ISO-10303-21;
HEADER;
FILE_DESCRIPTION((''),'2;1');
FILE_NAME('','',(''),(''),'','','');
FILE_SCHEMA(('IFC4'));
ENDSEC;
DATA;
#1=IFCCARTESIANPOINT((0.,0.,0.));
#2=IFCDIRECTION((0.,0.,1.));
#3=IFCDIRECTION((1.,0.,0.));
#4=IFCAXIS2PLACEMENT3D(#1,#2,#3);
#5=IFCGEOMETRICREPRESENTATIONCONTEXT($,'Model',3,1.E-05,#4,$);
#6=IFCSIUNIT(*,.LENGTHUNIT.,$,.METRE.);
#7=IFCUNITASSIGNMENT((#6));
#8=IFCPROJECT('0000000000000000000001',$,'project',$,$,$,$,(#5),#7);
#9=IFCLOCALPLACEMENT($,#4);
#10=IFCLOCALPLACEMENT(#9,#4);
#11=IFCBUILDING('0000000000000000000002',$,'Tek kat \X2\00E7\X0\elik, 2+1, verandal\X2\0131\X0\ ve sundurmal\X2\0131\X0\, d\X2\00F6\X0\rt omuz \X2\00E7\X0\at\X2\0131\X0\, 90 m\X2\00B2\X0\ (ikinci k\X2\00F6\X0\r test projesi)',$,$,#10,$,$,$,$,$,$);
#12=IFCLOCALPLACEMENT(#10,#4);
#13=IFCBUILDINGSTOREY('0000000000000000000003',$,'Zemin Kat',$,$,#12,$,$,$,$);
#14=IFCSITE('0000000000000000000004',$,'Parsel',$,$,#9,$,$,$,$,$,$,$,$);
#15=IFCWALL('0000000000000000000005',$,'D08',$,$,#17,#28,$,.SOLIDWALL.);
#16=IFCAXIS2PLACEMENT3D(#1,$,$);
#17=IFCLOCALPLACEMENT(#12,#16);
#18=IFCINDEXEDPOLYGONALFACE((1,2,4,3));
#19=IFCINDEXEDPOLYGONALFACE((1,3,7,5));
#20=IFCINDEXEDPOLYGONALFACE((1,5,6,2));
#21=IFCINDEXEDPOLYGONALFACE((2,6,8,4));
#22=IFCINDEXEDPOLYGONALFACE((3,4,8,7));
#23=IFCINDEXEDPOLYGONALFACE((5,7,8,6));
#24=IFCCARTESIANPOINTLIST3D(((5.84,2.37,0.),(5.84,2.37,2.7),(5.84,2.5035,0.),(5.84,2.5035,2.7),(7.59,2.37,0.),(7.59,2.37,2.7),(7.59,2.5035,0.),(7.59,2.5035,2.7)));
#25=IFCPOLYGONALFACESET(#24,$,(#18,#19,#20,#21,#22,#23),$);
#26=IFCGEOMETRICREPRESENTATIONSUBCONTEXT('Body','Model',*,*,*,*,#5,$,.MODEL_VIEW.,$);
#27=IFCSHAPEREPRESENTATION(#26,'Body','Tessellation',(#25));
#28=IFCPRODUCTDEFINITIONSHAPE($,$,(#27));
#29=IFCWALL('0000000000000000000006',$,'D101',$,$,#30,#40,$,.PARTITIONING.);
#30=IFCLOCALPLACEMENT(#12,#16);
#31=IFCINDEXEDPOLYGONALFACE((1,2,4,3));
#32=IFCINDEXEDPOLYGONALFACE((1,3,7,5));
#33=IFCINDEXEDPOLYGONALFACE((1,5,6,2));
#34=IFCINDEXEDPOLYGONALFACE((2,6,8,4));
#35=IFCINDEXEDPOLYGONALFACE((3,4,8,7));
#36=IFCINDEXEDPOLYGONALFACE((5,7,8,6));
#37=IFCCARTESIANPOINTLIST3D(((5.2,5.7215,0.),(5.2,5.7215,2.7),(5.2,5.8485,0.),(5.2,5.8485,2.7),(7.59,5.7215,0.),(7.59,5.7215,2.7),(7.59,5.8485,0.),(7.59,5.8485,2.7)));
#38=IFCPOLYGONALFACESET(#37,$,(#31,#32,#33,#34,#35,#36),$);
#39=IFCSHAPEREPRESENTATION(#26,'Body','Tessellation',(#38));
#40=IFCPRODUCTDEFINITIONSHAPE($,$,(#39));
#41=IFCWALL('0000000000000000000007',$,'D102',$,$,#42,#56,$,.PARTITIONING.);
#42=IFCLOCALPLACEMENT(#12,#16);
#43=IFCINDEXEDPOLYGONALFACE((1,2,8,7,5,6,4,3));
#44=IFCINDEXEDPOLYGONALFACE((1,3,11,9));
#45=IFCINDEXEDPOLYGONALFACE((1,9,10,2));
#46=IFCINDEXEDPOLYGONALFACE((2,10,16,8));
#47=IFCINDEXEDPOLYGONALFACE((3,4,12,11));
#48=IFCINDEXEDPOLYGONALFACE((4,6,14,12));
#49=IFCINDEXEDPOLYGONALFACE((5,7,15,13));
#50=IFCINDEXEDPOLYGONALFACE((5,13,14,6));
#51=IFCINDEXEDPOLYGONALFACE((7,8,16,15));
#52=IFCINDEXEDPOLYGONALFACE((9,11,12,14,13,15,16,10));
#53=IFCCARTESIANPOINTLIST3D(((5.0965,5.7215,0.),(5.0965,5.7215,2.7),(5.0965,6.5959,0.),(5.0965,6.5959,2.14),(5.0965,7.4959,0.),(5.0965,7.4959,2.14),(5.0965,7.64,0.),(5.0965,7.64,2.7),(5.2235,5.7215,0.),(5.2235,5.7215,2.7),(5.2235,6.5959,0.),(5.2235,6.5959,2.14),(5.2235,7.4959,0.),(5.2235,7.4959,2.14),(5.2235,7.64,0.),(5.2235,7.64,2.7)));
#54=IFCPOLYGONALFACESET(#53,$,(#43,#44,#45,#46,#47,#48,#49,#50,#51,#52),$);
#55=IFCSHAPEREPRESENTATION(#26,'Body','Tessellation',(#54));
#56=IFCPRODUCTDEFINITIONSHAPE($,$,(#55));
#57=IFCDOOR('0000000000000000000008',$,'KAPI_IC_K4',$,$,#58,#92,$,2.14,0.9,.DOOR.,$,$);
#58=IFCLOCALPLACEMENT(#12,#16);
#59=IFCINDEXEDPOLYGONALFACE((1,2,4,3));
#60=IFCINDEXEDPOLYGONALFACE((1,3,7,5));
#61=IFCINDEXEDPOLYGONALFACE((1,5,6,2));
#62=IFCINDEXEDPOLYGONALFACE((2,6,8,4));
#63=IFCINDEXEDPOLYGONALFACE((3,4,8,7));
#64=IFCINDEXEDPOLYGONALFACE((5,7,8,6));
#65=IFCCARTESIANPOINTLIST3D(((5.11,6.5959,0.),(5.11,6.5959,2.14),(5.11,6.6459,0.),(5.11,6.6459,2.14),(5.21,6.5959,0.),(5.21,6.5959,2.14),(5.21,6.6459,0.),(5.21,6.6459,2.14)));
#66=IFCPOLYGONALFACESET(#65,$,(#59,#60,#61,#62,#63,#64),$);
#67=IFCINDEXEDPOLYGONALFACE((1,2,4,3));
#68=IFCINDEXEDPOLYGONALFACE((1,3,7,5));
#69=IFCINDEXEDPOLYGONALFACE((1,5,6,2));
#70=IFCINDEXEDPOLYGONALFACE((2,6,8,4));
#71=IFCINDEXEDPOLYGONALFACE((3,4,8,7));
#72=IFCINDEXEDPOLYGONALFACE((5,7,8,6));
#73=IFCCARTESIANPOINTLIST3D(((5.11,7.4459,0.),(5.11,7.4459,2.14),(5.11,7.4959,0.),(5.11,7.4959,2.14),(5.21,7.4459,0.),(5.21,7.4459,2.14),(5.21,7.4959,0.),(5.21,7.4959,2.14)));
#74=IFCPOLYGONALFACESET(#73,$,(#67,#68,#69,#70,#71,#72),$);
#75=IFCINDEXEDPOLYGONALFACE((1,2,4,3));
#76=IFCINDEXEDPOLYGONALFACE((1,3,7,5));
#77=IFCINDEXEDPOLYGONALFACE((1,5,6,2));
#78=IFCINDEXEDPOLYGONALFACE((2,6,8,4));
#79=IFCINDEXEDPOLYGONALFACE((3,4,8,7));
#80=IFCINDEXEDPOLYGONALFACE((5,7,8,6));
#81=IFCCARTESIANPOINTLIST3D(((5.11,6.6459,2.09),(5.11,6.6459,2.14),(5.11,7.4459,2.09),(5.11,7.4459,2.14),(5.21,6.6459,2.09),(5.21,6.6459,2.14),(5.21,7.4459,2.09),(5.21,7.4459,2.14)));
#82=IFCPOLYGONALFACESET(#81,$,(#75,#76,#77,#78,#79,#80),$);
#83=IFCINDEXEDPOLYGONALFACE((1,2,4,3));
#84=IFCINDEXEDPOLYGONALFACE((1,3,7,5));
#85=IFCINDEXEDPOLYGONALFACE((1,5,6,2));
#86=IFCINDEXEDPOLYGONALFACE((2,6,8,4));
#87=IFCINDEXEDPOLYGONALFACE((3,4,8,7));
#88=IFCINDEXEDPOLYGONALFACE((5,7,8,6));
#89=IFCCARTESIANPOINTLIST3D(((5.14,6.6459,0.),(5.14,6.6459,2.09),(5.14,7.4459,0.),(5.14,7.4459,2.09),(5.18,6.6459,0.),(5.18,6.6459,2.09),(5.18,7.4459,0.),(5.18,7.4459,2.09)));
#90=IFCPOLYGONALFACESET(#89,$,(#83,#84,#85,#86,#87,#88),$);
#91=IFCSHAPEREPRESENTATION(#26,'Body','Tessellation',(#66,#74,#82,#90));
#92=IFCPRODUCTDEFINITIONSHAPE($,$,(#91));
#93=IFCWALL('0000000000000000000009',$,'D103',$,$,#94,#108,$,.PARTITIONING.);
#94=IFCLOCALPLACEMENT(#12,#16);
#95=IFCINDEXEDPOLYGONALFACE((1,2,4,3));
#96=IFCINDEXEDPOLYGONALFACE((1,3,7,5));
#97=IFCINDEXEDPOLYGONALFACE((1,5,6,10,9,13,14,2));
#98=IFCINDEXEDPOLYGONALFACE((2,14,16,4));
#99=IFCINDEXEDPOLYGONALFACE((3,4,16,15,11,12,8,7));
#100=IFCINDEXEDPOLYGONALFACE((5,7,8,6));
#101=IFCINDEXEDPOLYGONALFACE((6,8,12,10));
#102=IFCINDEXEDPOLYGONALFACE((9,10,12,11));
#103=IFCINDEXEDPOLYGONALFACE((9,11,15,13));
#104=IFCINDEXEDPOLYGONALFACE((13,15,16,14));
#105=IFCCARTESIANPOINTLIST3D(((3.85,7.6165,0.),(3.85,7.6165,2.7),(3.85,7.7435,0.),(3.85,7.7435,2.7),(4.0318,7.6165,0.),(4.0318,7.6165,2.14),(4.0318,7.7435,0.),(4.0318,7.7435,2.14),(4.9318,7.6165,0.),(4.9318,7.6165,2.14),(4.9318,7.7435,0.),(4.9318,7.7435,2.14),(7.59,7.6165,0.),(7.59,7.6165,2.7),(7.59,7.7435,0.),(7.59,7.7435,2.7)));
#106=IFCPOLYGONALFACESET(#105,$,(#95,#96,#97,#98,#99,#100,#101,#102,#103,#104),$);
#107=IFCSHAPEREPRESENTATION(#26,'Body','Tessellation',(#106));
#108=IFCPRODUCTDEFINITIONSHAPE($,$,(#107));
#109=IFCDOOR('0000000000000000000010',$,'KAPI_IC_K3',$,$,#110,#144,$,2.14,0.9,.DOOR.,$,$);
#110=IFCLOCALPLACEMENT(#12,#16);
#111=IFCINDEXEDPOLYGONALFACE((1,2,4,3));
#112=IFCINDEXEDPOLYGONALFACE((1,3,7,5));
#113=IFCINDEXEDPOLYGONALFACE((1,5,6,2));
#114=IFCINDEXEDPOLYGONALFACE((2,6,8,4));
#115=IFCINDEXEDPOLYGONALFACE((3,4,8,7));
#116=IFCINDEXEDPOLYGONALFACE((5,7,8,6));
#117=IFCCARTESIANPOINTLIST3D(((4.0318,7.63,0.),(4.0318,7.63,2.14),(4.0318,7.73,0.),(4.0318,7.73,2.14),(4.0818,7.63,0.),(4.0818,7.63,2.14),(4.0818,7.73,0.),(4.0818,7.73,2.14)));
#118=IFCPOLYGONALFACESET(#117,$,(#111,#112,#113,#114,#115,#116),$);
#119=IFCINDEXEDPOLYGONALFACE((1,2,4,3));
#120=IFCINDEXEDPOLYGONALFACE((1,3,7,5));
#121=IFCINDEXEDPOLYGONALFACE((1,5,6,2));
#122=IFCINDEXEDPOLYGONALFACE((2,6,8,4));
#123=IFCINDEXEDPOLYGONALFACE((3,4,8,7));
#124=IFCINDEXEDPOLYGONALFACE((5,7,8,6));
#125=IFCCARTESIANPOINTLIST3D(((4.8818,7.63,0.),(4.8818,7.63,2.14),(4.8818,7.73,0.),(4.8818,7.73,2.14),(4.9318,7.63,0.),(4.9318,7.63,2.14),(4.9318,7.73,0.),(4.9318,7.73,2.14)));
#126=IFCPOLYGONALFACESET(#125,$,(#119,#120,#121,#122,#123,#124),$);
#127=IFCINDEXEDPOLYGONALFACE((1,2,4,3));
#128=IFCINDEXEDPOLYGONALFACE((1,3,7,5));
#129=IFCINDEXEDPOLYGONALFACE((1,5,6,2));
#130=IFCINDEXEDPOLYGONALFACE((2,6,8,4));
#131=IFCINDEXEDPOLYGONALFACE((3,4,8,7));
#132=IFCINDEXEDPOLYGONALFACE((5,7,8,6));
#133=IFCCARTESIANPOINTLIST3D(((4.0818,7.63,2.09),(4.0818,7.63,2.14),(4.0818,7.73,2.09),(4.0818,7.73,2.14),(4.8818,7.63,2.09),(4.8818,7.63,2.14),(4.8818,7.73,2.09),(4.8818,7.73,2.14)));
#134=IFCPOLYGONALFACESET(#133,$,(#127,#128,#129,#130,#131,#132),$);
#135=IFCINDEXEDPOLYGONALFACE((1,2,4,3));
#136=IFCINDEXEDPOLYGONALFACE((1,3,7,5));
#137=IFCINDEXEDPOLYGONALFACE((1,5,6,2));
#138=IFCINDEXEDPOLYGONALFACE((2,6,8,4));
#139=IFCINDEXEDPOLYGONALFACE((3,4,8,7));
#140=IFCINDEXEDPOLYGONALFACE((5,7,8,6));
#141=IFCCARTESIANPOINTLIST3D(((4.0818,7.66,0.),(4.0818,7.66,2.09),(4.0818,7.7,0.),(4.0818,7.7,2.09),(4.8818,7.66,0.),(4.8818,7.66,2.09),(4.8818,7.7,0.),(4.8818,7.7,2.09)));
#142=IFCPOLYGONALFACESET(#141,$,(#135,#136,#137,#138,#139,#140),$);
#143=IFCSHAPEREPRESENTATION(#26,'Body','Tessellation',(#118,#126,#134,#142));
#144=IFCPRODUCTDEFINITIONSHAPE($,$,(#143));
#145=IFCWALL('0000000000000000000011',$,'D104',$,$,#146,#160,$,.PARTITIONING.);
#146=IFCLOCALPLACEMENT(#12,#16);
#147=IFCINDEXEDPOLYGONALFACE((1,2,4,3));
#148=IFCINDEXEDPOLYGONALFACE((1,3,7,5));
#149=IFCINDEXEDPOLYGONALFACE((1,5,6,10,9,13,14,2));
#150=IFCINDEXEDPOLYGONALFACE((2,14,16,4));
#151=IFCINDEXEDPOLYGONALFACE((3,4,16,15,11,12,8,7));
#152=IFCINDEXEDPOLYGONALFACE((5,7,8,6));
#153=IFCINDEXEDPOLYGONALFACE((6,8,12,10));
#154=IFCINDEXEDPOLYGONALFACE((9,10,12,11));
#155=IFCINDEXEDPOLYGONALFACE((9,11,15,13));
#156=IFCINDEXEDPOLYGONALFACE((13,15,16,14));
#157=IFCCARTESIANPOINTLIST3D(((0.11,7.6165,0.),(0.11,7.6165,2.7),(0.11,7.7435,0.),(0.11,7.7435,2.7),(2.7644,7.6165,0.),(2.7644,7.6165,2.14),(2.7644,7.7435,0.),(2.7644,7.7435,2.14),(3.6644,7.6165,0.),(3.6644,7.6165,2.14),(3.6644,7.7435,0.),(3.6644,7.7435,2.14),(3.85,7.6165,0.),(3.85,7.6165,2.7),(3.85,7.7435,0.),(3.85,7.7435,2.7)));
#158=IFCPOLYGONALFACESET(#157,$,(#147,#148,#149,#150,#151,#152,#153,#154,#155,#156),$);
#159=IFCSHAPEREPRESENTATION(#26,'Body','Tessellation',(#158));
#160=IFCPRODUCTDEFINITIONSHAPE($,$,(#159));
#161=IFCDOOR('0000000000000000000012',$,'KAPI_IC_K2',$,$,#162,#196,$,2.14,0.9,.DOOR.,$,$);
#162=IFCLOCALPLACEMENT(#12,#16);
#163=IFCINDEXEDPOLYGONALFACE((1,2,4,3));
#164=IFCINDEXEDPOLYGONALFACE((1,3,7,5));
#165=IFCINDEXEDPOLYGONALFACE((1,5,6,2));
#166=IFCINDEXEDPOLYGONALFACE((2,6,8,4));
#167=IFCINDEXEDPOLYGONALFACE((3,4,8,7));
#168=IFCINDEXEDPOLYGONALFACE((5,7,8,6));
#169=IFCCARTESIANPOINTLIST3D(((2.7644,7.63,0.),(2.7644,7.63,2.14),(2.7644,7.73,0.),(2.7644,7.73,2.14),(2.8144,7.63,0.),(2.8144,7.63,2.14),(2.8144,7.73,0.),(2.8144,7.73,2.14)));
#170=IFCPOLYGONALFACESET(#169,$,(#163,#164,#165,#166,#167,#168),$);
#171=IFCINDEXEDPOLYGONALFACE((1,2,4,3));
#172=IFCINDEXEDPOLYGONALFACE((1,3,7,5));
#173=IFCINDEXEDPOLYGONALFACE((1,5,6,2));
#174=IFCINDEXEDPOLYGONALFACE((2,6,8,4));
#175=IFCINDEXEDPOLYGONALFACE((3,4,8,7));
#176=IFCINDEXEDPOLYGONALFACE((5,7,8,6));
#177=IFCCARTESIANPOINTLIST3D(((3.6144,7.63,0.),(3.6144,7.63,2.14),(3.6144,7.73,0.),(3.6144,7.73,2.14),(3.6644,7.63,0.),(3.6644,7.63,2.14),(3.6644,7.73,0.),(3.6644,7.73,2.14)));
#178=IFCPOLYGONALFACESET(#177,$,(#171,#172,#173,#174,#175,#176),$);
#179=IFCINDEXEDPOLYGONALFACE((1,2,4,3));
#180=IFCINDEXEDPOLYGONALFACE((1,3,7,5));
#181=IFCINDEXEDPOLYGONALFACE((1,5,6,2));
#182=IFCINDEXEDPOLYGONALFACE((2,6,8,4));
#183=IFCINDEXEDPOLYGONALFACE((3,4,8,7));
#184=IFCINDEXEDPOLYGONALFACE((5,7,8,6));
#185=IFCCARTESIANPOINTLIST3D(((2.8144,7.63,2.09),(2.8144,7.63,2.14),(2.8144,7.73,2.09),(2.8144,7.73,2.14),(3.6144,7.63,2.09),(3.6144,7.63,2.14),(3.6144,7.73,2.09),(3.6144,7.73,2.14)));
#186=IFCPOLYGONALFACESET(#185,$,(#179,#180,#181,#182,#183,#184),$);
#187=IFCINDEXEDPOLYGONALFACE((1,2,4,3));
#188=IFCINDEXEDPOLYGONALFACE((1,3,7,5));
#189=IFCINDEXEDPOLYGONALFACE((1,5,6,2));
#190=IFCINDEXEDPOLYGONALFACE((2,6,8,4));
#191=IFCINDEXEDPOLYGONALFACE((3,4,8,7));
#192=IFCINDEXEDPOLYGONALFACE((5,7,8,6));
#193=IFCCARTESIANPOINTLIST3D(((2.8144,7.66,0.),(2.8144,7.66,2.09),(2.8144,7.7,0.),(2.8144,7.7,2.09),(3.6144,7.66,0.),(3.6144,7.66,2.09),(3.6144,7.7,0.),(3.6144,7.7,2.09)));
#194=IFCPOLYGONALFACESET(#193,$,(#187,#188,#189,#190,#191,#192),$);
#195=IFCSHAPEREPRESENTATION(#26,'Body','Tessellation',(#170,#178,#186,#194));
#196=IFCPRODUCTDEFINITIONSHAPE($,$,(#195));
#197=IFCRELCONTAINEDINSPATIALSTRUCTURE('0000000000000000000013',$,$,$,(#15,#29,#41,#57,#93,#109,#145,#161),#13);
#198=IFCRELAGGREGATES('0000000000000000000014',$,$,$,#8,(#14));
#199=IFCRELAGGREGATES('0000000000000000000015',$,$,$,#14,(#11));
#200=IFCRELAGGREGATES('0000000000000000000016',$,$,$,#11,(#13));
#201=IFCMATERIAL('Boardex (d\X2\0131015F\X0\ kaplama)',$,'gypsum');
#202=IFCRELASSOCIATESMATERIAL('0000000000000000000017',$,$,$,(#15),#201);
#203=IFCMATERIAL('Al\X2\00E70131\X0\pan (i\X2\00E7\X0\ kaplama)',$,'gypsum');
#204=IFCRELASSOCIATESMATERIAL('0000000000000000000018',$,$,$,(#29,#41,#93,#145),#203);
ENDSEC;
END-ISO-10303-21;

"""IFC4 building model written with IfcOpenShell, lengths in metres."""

from ifc_helpers import new_model, si_unit, frame, origin_with_axes, place, context, subcontext, project, spatial, line, indexed_curve, outline, extrude, material, element, fill, save


model = new_model("IFC4")

# Units and contexts
model_context = context("Model", 3, precision=1e-05, world=origin_with_axes())
body_context = subcontext(model_context, "Body", "Model", "MODEL_VIEW")
ifc_project = project(units=[si_unit("LENGTHUNIT", "METRE")], contexts=[model_context])

# Site, building, storey
site_placement = place(None, origin_with_axes())
site = spatial("IfcSite", under=ifc_project, at=site_placement, Name="Parsel")
building_placement = place(site_placement, origin_with_axes())
building = spatial("IfcBuilding", under=site, at=building_placement, Name="Tek kat çelik, 2+1, verandalı ve sundurmalı, dört omuz çatı, 90 m² (ikinci kör test projesi)")
storey_placement = place(building_placement, origin_with_axes())
storey = spatial("IfcBuildingStorey", under=building, at=storey_placement, Name="Zemin Kat")

# Shared definitions
ifc_material_1 = material(Name="Boardex (dış kaplama)", Category="gypsum")

# Walls
wall_1_placement = place(storey_placement, origin_with_axes())
element("IfcWall", 1, at=wall_1_placement, inside=storey, material=ifc_material_1, Name="D08", PredefinedType="SOLIDWALL", context=body_context, shape_type="SweptSolid", body=[
    extrude(outline(indexed_curve([(0.0, 0.0), (1.75, 0.0), (1.75, 0.1335), (0.0, 0.1335)], segments=[line(1, 2, 3, 4, 1)])), frame((5.84, 2.37, 0.0), z_axis=(0.0, 0.0, 1.0), x_axis=(1.0, 0.0, 0.0)), (0.0, 0.0, 1.0), 2.7),
])
ifc_material_2 = material(Name="Alçıpan (iç kaplama)", Category="gypsum")
wall_2_placement = place(storey_placement, origin_with_axes())
element("IfcWall", 2, at=wall_2_placement, inside=storey, material=ifc_material_2, Name="D101", PredefinedType="PARTITIONING", context=body_context, shape_type="SweptSolid", body=[
    extrude(outline(indexed_curve([(0.0, 0.0), (2.39, 0.0), (2.39, 0.127), (0.0, 0.127)], segments=[line(1, 2, 3, 4, 1)])), frame((5.2, 5.7215, 0.0), z_axis=(0.0, 0.0, 1.0), x_axis=(1.0, 0.0, 0.0)), (0.0, 0.0, 1.0), 2.7),
])

# Walls, openings, doors
wall_3_placement = place(storey_placement, origin_with_axes())
wall_3 = element("IfcWall", 3, at=wall_3_placement, inside=storey, material=ifc_material_2, Name="D102", PredefinedType="PARTITIONING", context=body_context, shape_type="SweptSolid", body=[
    extrude(outline(indexed_curve([(0.0, 0.0), (0.127, 0.0), (0.127, 1.9185), (0.0, 1.9185)], segments=[line(1, 2, 3, 4, 1)])), frame((5.0965, 5.7215, 0.0), z_axis=(0.0, 0.0, 1.0), x_axis=(1.0, 0.0, 0.0)), (0.0, 0.0, 1.0), 2.7),
])
opening_1_placement = place(wall_3_placement, origin_with_axes())
opening_1 = element("IfcOpeningElement", 4, at=opening_1_placement, cuts=wall_3, PredefinedType="OPENING", context=body_context, shape_type="SweptSolid", body=[
    extrude(outline(indexed_curve([(0.0, 0.0), (0.167, 0.0), (0.167, 0.9), (0.0, 0.9)], segments=[line(1, 2, 3, 4, 1)])), frame((5.0765, 6.5959, 0.0), z_axis=(0.0, 0.0, 1.0), x_axis=(1.0, 0.0, 0.0)), (0.0, 0.0, 1.0), 2.14),
])
door_1_placement = place(storey_placement, origin_with_axes())
door_1 = element("IfcDoor", 5, at=door_1_placement, inside=storey, Name="KAPI_IC_K4", OverallHeight=2.14, OverallWidth=0.9, PredefinedType="DOOR", context=body_context, shape_type="SweptSolid", body=[
    extrude(outline(indexed_curve([(0.0, 0.0), (0.1, 0.0), (0.1, 0.05), (0.0, 0.05)], segments=[line(1, 2, 3, 4, 1)])), frame((5.11, 6.5959, 0.0), z_axis=(0.0, 0.0, 1.0), x_axis=(1.0, 0.0, 0.0)), (0.0, 0.0, 1.0), 2.14),
    extrude(outline(indexed_curve([(0.0, 0.0), (0.1, 0.0), (0.1, 0.05), (0.0, 0.05)], segments=[line(1, 2, 3, 4, 1)])), frame((5.11, 7.4459, 0.0), z_axis=(0.0, 0.0, 1.0), x_axis=(1.0, 0.0, 0.0)), (0.0, 0.0, 1.0), 2.14),
    extrude(outline(indexed_curve([(0.0, 0.0), (0.1, 0.0), (0.1, 0.8), (0.0, 0.8)], segments=[line(1, 2, 3, 4, 1)])), frame((5.11, 6.6459, 2.09), z_axis=(0.0, 0.0, 1.0), x_axis=(1.0, 0.0, 0.0)), (0.0, 0.0, 1.0), 0.05),
    extrude(outline(indexed_curve([(0.0, 0.0), (0.04, 0.0), (0.04, 0.8), (0.0, 0.8)], segments=[line(1, 2, 3, 4, 1)])), frame((5.14, 6.6459, 0.0), z_axis=(0.0, 0.0, 1.0), x_axis=(1.0, 0.0, 0.0)), (0.0, 0.0, 1.0), 2.09),
])
fill(opening_1, door_1)
wall_4_placement = place(storey_placement, origin_with_axes())
wall_4 = element("IfcWall", 6, at=wall_4_placement, inside=storey, material=ifc_material_2, Name="D103", PredefinedType="PARTITIONING", context=body_context, shape_type="SweptSolid", body=[
    extrude(outline(indexed_curve([(0.0, 0.0), (3.74, 0.0), (3.74, 0.127), (0.0, 0.127)], segments=[line(1, 2, 3, 4, 1)])), frame((3.85, 7.6165, 0.0), z_axis=(0.0, 0.0, 1.0), x_axis=(1.0, 0.0, 0.0)), (0.0, 0.0, 1.0), 2.7),
])
opening_2_placement = place(wall_4_placement, origin_with_axes())
opening_2 = element("IfcOpeningElement", 7, at=opening_2_placement, cuts=wall_4, PredefinedType="OPENING", context=body_context, shape_type="SweptSolid", body=[
    extrude(outline(indexed_curve([(0.0, 0.0), (0.9, 0.0), (0.9, 0.167), (0.0, 0.167)], segments=[line(1, 2, 3, 4, 1)])), frame((4.0318, 7.5965, 0.0), z_axis=(0.0, 0.0, 1.0), x_axis=(1.0, 0.0, 0.0)), (0.0, 0.0, 1.0), 2.14),
])
door_2_placement = place(storey_placement, origin_with_axes())
door_2 = element("IfcDoor", 8, at=door_2_placement, inside=storey, Name="KAPI_IC_K3", OverallHeight=2.14, OverallWidth=0.9, PredefinedType="DOOR", context=body_context, shape_type="SweptSolid", body=[
    extrude(outline(indexed_curve([(0.0, 0.0), (0.05, 0.0), (0.05, 0.1), (0.0, 0.1)], segments=[line(1, 2, 3, 4, 1)])), frame((4.0318, 7.63, 0.0), z_axis=(0.0, 0.0, 1.0), x_axis=(1.0, 0.0, 0.0)), (0.0, 0.0, 1.0), 2.14),
    extrude(outline(indexed_curve([(0.0, 0.0), (0.05, 0.0), (0.05, 0.1), (0.0, 0.1)], segments=[line(1, 2, 3, 4, 1)])), frame((4.8818, 7.63, 0.0), z_axis=(0.0, 0.0, 1.0), x_axis=(1.0, 0.0, 0.0)), (0.0, 0.0, 1.0), 2.14),
    extrude(outline(indexed_curve([(0.0, 0.0), (0.8, 0.0), (0.8, 0.1), (0.0, 0.1)], segments=[line(1, 2, 3, 4, 1)])), frame((4.0818, 7.63, 2.09), z_axis=(0.0, 0.0, 1.0), x_axis=(1.0, 0.0, 0.0)), (0.0, 0.0, 1.0), 0.05),
    extrude(outline(indexed_curve([(0.0, 0.0), (0.8, 0.0), (0.8, 0.04), (0.0, 0.04)], segments=[line(1, 2, 3, 4, 1)])), frame((4.0818, 7.66, 0.0), z_axis=(0.0, 0.0, 1.0), x_axis=(1.0, 0.0, 0.0)), (0.0, 0.0, 1.0), 2.09),
])
fill(opening_2, door_2)
wall_5_placement = place(storey_placement, origin_with_axes())
wall_5 = element("IfcWall", 9, at=wall_5_placement, inside=storey, material=ifc_material_2, Name="D104", PredefinedType="PARTITIONING", context=body_context, shape_type="SweptSolid", body=[
    extrude(outline(indexed_curve([(0.0, 0.0), (3.74, 0.0), (3.74, 0.127), (0.0, 0.127)], segments=[line(1, 2, 3, 4, 1)])), frame((0.11, 7.6165, 0.0), z_axis=(0.0, 0.0, 1.0), x_axis=(1.0, 0.0, 0.0)), (0.0, 0.0, 1.0), 2.7),
])
opening_3_placement = place(wall_5_placement, origin_with_axes())
opening_3 = element("IfcOpeningElement", 10, at=opening_3_placement, cuts=wall_5, PredefinedType="OPENING", context=body_context, shape_type="SweptSolid", body=[
    extrude(outline(indexed_curve([(0.0, 0.0), (0.9, 0.0), (0.9, 0.167), (0.0, 0.167)], segments=[line(1, 2, 3, 4, 1)])), frame((2.7644, 7.5965, 0.0), z_axis=(0.0, 0.0, 1.0), x_axis=(1.0, 0.0, 0.0)), (0.0, 0.0, 1.0), 2.14),
])
door_3_placement = place(storey_placement, origin_with_axes())
door_3 = element("IfcDoor", 11, at=door_3_placement, inside=storey, Name="KAPI_IC_K2", OverallHeight=2.14, OverallWidth=0.9, PredefinedType="DOOR", context=body_context, shape_type="SweptSolid", body=[
    extrude(outline(indexed_curve([(0.0, 0.0), (0.05, 0.0), (0.05, 0.1), (0.0, 0.1)], segments=[line(1, 2, 3, 4, 1)])), frame((2.7644, 7.63, 0.0), z_axis=(0.0, 0.0, 1.0), x_axis=(1.0, 0.0, 0.0)), (0.0, 0.0, 1.0), 2.14),
    extrude(outline(indexed_curve([(0.0, 0.0), (0.05, 0.0), (0.05, 0.1), (0.0, 0.1)], segments=[line(1, 2, 3, 4, 1)])), frame((3.6144, 7.63, 0.0), z_axis=(0.0, 0.0, 1.0), x_axis=(1.0, 0.0, 0.0)), (0.0, 0.0, 1.0), 2.14),
    extrude(outline(indexed_curve([(0.0, 0.0), (0.8, 0.0), (0.8, 0.1), (0.0, 0.1)], segments=[line(1, 2, 3, 4, 1)])), frame((2.8144, 7.63, 2.09), z_axis=(0.0, 0.0, 1.0), x_axis=(1.0, 0.0, 0.0)), (0.0, 0.0, 1.0), 0.05),
    extrude(outline(indexed_curve([(0.0, 0.0), (0.8, 0.0), (0.8, 0.04), (0.0, 0.04)], segments=[line(1, 2, 3, 4, 1)])), frame((2.8144, 7.66, 0.0), z_axis=(0.0, 0.0, 1.0), x_axis=(1.0, 0.0, 0.0)), (0.0, 0.0, 1.0), 2.09),
])
fill(opening_3, door_3)

save(model, "model.ifc")
